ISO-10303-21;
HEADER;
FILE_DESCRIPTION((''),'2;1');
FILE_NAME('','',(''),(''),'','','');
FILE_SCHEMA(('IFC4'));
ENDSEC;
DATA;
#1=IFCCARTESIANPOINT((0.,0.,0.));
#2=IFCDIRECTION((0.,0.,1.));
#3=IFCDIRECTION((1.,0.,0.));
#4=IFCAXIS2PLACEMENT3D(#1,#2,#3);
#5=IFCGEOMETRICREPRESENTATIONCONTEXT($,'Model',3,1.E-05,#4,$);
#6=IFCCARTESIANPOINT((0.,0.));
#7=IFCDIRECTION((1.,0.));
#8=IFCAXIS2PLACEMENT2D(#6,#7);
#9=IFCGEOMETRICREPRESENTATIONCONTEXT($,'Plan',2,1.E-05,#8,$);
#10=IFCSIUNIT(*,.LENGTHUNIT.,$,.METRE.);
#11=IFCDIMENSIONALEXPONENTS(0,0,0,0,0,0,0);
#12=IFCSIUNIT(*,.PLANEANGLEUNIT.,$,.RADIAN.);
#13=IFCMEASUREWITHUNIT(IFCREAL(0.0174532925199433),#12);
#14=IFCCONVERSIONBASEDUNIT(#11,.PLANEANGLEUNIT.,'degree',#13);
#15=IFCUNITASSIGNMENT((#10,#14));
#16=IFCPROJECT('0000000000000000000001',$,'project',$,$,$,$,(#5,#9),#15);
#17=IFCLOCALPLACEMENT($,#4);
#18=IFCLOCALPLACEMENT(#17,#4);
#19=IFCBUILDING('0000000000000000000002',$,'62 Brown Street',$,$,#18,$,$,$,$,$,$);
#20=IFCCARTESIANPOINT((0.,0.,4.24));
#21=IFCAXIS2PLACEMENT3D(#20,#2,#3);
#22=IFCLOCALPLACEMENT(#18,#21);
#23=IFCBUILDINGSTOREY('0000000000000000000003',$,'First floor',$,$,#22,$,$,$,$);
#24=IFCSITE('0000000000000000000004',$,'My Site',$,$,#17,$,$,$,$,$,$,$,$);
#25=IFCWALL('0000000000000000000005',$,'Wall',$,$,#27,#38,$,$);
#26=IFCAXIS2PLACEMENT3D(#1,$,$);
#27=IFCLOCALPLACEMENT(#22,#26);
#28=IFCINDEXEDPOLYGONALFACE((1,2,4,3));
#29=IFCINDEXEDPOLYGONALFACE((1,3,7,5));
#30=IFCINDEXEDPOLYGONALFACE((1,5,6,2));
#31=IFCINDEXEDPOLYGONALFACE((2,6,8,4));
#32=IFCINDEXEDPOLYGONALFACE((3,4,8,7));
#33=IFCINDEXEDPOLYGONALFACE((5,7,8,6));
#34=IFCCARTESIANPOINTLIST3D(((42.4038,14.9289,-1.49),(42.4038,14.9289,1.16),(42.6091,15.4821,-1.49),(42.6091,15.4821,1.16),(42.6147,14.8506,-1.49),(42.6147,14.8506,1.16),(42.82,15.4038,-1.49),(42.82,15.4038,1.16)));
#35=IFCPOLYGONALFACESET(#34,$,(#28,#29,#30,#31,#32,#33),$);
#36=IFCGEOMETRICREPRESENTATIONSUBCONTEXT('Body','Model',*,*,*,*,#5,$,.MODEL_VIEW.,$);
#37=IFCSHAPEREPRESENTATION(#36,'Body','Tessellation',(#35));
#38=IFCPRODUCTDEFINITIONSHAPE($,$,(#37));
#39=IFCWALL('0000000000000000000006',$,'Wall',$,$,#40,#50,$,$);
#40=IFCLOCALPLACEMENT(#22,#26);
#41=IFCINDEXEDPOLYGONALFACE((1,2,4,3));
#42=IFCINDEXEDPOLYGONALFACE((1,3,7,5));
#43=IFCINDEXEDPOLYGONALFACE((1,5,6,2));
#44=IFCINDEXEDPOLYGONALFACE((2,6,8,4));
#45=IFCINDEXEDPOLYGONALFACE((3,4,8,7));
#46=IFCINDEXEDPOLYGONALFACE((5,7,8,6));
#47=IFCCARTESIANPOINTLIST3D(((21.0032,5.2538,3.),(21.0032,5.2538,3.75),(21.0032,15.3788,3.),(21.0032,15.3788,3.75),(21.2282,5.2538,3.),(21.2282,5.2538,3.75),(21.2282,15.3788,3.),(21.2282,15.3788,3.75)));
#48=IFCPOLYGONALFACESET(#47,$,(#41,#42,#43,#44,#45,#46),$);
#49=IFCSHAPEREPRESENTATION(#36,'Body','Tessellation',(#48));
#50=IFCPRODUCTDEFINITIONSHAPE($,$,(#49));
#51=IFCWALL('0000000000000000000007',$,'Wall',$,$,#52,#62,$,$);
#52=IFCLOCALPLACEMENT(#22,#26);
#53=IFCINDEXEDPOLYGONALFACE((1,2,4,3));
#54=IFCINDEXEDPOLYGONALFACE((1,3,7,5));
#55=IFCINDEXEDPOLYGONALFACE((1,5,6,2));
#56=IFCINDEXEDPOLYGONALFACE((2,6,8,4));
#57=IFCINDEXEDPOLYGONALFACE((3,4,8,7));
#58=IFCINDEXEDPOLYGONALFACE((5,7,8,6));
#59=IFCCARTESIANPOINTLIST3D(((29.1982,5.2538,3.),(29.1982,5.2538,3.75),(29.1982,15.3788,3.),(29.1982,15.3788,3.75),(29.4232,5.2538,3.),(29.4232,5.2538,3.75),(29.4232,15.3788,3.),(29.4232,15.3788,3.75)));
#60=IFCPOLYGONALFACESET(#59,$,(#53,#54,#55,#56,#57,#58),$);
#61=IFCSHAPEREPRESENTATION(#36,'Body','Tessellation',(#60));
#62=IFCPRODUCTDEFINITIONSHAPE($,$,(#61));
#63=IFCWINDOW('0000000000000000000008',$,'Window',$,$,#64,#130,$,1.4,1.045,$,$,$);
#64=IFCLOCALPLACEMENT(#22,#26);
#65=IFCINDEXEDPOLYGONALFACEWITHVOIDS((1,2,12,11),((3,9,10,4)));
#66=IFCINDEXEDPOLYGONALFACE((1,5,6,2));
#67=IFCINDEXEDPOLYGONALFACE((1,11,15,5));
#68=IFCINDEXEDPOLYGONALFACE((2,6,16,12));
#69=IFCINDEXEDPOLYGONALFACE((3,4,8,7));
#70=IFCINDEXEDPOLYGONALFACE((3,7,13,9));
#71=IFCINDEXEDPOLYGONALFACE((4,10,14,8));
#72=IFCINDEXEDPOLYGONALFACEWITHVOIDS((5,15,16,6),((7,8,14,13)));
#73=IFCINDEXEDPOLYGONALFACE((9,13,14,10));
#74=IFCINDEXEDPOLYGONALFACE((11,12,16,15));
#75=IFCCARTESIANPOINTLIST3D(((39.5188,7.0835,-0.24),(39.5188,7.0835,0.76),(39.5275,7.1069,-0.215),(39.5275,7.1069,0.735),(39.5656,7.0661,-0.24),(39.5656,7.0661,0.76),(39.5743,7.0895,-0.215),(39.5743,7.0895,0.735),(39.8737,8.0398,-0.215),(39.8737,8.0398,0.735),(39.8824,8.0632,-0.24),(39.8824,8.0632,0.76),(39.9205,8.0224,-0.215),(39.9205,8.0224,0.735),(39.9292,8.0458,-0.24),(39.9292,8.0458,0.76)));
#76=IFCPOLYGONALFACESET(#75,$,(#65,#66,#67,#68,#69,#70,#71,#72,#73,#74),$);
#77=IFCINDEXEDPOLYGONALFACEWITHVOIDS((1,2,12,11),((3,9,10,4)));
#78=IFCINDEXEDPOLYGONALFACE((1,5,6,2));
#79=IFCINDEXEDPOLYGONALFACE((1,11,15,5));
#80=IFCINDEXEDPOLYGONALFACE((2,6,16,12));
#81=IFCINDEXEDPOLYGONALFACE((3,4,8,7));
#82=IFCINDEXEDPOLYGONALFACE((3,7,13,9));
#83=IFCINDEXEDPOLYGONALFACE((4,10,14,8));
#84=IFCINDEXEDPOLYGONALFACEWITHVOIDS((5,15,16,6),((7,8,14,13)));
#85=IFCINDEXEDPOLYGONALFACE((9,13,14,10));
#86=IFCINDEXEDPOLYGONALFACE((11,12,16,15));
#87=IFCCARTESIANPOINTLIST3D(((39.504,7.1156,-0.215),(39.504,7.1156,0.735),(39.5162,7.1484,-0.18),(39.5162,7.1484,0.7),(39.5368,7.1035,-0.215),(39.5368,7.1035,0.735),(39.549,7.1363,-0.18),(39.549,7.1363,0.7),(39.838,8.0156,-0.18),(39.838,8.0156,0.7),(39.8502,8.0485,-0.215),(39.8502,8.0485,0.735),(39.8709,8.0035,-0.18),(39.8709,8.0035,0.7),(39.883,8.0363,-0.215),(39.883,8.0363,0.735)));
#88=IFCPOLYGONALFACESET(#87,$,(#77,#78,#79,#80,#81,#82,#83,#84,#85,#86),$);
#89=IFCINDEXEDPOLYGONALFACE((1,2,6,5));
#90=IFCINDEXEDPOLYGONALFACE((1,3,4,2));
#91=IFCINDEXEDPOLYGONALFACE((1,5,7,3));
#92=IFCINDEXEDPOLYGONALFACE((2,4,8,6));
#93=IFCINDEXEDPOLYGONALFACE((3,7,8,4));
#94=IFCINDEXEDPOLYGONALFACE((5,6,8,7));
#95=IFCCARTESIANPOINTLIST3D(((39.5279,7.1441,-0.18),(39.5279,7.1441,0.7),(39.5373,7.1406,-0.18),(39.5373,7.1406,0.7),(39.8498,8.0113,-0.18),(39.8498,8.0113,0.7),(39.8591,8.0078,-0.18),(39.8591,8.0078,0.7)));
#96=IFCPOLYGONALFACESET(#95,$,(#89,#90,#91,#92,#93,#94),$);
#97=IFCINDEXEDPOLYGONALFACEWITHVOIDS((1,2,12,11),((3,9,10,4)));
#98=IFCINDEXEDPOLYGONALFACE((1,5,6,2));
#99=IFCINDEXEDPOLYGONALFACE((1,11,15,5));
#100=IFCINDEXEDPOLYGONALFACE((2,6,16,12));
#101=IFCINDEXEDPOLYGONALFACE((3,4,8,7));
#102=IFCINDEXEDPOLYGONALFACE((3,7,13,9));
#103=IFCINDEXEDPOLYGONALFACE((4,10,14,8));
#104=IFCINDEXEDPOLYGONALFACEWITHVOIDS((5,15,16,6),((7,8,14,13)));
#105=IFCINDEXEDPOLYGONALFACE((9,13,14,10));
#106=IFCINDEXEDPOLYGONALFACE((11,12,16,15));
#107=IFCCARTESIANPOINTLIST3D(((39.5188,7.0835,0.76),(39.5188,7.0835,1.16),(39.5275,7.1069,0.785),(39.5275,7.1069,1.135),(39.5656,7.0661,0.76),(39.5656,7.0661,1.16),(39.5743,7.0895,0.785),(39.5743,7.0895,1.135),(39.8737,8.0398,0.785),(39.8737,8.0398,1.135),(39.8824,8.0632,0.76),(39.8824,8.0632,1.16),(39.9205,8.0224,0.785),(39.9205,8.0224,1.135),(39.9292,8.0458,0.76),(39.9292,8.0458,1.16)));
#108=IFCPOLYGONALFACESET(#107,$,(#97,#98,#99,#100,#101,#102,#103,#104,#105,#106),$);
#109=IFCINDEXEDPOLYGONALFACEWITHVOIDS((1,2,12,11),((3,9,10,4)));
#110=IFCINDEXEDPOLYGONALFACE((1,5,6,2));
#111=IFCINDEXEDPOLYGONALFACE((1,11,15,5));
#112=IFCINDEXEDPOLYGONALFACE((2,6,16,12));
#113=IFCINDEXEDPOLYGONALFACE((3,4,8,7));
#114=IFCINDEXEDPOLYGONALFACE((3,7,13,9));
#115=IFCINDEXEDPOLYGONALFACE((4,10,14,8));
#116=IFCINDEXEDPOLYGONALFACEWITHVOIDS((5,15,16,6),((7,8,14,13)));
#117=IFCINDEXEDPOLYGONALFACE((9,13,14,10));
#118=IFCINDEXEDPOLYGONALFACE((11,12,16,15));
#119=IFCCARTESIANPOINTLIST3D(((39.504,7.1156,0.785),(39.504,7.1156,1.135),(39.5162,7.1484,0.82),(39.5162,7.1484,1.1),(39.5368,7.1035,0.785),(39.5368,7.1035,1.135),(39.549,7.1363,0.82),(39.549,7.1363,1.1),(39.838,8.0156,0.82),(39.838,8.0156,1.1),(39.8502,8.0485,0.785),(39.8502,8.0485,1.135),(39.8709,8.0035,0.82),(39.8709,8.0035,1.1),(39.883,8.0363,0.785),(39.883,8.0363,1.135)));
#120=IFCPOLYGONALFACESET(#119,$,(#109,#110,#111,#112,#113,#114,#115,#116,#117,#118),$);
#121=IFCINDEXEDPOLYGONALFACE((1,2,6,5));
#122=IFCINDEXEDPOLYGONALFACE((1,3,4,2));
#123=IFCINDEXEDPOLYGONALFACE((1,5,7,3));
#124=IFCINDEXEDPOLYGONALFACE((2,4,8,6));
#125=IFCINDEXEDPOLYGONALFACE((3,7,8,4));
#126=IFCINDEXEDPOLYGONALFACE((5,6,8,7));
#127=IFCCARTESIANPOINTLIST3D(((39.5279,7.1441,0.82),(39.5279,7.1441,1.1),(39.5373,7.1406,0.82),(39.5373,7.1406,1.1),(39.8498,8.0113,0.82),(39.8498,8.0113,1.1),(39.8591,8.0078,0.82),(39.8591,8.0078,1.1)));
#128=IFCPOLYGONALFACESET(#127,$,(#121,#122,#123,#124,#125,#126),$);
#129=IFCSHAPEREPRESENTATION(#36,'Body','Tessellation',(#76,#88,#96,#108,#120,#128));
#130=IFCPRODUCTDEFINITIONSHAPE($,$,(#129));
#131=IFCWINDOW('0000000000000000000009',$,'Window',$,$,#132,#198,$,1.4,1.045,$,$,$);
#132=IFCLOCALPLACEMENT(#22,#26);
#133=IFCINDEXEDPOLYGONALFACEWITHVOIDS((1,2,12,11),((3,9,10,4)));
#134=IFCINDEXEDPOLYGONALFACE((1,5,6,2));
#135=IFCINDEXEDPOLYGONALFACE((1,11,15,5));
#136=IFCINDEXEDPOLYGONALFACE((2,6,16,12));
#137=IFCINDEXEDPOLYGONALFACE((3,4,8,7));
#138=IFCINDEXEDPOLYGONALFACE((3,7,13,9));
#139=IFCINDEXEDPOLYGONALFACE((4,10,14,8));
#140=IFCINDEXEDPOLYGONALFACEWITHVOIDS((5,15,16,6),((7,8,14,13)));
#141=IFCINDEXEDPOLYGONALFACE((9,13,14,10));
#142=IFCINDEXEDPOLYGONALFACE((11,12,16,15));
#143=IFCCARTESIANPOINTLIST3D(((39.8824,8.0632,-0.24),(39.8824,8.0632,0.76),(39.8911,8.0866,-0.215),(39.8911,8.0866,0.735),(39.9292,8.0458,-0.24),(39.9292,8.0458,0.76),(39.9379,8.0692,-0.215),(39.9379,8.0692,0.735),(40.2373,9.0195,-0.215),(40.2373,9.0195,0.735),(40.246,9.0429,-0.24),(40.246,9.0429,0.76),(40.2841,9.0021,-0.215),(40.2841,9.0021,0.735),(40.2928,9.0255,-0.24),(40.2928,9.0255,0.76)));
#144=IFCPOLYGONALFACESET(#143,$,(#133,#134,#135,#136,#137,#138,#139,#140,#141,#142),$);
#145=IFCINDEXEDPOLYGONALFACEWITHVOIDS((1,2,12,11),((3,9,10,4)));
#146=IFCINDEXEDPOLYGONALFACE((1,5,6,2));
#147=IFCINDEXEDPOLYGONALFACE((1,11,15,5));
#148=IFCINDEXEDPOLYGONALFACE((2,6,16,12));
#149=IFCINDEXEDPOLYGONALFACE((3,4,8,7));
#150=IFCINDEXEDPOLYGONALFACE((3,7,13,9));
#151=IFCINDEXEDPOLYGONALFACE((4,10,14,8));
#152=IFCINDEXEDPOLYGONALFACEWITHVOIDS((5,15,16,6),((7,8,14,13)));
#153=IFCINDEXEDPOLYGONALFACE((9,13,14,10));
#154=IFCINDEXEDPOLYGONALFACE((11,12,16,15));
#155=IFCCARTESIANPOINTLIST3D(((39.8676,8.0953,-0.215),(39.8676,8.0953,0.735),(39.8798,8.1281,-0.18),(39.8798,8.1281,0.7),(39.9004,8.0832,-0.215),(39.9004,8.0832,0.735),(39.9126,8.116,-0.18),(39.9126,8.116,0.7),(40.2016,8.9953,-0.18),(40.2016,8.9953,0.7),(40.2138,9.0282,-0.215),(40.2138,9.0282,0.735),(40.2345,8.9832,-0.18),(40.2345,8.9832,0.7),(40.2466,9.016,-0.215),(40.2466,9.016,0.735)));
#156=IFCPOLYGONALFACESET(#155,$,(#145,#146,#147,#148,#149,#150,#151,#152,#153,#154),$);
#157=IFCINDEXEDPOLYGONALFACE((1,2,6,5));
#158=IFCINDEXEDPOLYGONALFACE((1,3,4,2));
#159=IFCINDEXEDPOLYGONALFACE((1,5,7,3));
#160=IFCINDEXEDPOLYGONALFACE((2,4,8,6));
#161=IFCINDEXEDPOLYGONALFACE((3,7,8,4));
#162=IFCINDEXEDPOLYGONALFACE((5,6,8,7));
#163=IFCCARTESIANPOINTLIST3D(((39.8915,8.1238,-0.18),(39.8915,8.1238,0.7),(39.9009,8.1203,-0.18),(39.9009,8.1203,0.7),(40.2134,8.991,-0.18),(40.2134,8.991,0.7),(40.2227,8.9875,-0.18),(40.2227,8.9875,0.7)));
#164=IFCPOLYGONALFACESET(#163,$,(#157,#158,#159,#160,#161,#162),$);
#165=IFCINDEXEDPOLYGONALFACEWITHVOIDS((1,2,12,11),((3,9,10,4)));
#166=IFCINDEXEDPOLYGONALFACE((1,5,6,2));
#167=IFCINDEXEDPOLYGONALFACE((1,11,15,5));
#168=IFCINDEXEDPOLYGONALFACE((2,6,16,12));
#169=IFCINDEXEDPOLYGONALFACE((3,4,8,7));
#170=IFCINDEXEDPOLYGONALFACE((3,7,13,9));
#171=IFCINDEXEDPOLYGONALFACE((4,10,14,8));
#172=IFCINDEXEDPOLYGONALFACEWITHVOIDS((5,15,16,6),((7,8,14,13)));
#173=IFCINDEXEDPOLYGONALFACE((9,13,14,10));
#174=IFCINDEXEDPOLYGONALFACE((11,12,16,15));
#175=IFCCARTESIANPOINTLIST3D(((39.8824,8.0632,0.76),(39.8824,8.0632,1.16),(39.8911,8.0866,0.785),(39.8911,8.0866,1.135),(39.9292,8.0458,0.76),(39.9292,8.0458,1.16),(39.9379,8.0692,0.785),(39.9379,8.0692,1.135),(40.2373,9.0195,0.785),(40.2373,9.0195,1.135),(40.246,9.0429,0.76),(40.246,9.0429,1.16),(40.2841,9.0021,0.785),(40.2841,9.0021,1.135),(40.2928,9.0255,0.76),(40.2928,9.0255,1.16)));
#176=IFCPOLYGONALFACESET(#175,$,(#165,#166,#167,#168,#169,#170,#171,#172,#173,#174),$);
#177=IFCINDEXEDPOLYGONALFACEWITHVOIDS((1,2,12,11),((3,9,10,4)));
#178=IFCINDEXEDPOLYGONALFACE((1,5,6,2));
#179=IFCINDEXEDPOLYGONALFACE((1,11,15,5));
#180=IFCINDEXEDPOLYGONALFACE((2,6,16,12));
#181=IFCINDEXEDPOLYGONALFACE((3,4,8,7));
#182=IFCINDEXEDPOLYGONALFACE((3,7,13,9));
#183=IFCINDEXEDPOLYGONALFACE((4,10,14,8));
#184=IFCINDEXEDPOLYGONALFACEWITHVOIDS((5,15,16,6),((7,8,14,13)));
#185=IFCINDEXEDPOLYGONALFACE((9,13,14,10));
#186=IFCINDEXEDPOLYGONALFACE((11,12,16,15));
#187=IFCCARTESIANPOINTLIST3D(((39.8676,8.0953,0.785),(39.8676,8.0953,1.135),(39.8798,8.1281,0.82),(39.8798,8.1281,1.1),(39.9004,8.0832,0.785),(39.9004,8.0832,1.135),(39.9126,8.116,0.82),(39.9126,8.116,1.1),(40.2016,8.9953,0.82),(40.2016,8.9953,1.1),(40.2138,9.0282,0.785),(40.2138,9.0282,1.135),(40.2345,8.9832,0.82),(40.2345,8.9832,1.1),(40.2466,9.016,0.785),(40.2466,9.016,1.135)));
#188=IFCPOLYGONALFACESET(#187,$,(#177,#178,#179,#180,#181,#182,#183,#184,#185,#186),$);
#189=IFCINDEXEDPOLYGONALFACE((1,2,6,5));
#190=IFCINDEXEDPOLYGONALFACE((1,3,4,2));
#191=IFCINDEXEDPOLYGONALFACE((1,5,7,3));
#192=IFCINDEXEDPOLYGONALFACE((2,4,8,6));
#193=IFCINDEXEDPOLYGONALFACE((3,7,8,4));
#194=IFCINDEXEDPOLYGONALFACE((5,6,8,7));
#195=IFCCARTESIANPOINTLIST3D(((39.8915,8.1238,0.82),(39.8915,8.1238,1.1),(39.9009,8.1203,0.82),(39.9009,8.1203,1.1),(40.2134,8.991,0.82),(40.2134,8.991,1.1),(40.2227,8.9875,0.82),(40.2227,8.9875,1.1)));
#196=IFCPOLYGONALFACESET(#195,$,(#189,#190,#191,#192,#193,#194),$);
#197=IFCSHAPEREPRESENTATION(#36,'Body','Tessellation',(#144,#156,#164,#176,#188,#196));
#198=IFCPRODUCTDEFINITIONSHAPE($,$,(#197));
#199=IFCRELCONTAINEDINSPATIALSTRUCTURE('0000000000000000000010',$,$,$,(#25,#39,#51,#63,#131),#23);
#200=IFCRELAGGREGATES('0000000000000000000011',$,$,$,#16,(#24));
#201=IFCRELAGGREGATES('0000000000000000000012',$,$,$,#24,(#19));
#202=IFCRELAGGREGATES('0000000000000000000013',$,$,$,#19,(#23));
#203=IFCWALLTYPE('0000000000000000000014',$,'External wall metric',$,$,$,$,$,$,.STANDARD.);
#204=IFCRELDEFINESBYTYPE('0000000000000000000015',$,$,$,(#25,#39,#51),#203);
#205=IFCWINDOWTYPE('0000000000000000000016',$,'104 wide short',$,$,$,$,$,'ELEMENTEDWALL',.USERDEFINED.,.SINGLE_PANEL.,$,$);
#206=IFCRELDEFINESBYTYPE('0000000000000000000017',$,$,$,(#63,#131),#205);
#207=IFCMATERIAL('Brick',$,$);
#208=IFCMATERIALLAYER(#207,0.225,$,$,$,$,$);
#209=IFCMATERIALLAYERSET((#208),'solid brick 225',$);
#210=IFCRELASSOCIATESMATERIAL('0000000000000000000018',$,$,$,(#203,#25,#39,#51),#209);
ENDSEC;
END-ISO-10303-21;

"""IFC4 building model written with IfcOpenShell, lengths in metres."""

from ifc_helpers import new_model, entity, si_unit, converted_unit, frame, origin_with_axes, origin_2d_with_axis, place, context, subcontext, project, spatial, line, indexed_curve, outline, extrude, shape, source, transform, mapped, material, layer, layer_set, layer_usage, type_object, type_shapes, element, save


model = new_model("IFC4")

# Units and contexts
model_context = context("Model", 3, precision=1e-05, world=origin_with_axes())
plan_context = context("Plan", 2, precision=1e-05, world=origin_2d_with_axis())
body_context_1 = subcontext(model_context, "Body", "Model", "MODEL_VIEW")
body_context_2 = subcontext(plan_context, "Body", "Plan", "PLAN_VIEW")
ifc_project = project(units=[si_unit("LENGTHUNIT", "METRE"), converted_unit("PLANEANGLEUNIT", "degree", entity("IfcReal", 0.0174532925199433), si_unit("PLANEANGLEUNIT", "RADIAN"), dimensions=[0, 0, 0, 0, 0, 0, 0])], contexts=[model_context, plan_context])

# Site, building, storey
site_placement = place(None, origin_with_axes())
site = spatial("IfcSite", under=ifc_project, at=site_placement, Name="My Site")
building_placement = place(site_placement, origin_with_axes())
building = spatial("IfcBuilding", under=site, at=building_placement, Name="62 Brown Street")
storey_placement = place(building_placement, frame((0.0, 0.0, 4.24), z_axis=(0.0, 0.0, 1.0), x_axis=(1.0, 0.0, 0.0)))
storey = spatial("IfcBuildingStorey", under=building, at=storey_placement, Name="First floor")

# Shared definitions
ifc_material_1 = material(Name="Brick")
ifc_layer_1 = layer(ifc_material_1, 0.225)
ifc_layer_set_1 = layer_set([ifc_layer_1], Name="solid brick 225")
wall_type_1 = type_object("IfcWallType", Name="External wall metric", PredefinedType="STANDARD", material=ifc_layer_set_1)

# Shared definitions
window_type = type_object("IfcWindowType", Name="104 wide short", ElementType="ELEMENTEDWALL", PartitioningType="SINGLE_PANEL", PredefinedType="USERDEFINED")
shared_shape_1 = source(origin_with_axes(), body_context_1, "Body", "SweptSolid", [
    extrude(outline(indexed_curve([(0.0, 0.0), (1.045, 0.0), (1.045, 1.0), (0.0, 1.0)], segments=[line(1, 2, 3, 4, 1)]), holes=[indexed_curve([(0.025, 0.025), (1.02, 0.025), (1.02, 0.975), (0.025, 0.975)], segments=[line(1, 2, 3, 4, 1)])]), frame((0.0, 0.15, 0.0), z_axis=(0.0, -1.0, 0.0), x_axis=(1.0, 0.0, 0.0)), (0.0, 0.0, -1.0), 0.05),
    extrude(outline(indexed_curve([(0.0, 0.0), (0.995, 0.0), (0.995, 0.95), (0.0, 0.95)], segments=[line(1, 2, 3, 4, 1)]), holes=[indexed_curve([(0.035, 0.035), (0.96, 0.035), (0.96, 0.915), (0.035, 0.915)], segments=[line(1, 2, 3, 4, 1)])]), frame((0.025, 0.19, 0.025), z_axis=(0.0, -1.0, 0.0), x_axis=(1.0, 0.0, 0.0)), (0.0, 0.0, -1.0), 0.035),
    extrude(outline(indexed_curve([(0.035, 0.035), (0.96, 0.035), (0.96, 0.915), (0.035, 0.915)], segments=[line(1, 2, 3, 4, 1)])), frame((0.025, 0.2025, 0.025), z_axis=(0.0, -1.0, 0.0), x_axis=(1.0, 0.0, 0.0)), (0.0, 0.0, -1.0), 0.01),
    extrude(outline(indexed_curve([(0.0, 0.0), (1.045, 0.0), (1.045, 0.4), (0.0, 0.4)], segments=[line(1, 2, 3, 4, 1)]), holes=[indexed_curve([(0.025, 0.025), (1.02, 0.025), (1.02, 0.375), (0.025, 0.375)], segments=[line(1, 2, 3, 4, 1)])]), frame((0.0, 0.15, 1.0), z_axis=(0.0, -1.0, 0.0), x_axis=(1.0, 0.0, 0.0)), (0.0, 0.0, -1.0), 0.05),
    extrude(outline(indexed_curve([(0.0, 0.0), (0.995, 0.0), (0.995, 0.35), (0.0, 0.35)], segments=[line(1, 2, 3, 4, 1)]), holes=[indexed_curve([(0.035, 0.035), (0.96, 0.035), (0.96, 0.315), (0.035, 0.315)], segments=[line(1, 2, 3, 4, 1)])]), frame((0.025, 0.19, 1.025), z_axis=(0.0, -1.0, 0.0), x_axis=(1.0, 0.0, 0.0)), (0.0, 0.0, -1.0), 0.035),
    extrude(outline(indexed_curve([(0.035, 0.035), (0.96, 0.035), (0.96, 0.315), (0.035, 0.315)], segments=[line(1, 2, 3, 4, 1)])), frame((0.025, 0.2025, 1.025), z_axis=(0.0, -1.0, 0.0), x_axis=(1.0, 0.0, 0.0)), (0.0, 0.0, -1.0), 0.01),
])
shared_shape_2 = source(origin_with_axes(), body_context_2, "Body", "Curve2D", [
    entity("IfcIndexedPolyCurve", entity("IfcCartesianPointList2D", [[0.025, 0.15], [1.02, 0.15]])),
    entity("IfcIndexedPolyCurve", entity("IfcCartesianPointList2D", [[0.0, 0.2], [0.025, 0.2], [0.025, 0.15], [0.0, 0.15]]), [entity("IfcLineIndex", [1, 2, 3, 4, 1])]),
    entity("IfcIndexedPolyCurve", entity("IfcCartesianPointList2D", [[1.045, 0.2], [1.02, 0.2], [1.02, 0.15], [1.045, 0.15]]), [entity("IfcLineIndex", [1, 2, 3, 4, 1])]),
    entity("IfcIndexedPolyCurve", entity("IfcCartesianPointList2D", [[0.025, 0.19], [0.06, 0.19], [0.06, 0.225], [0.025, 0.225]]), [entity("IfcLineIndex", [1, 2, 3, 4, 1])]),
    entity("IfcIndexedPolyCurve", entity("IfcCartesianPointList2D", [[1.02, 0.19], [0.985, 0.19], [0.985, 0.225], [1.02, 0.225]]), [entity("IfcLineIndex", [1, 2, 3, 4, 1])]),
    entity("IfcIndexedPolyCurve", entity("IfcCartesianPointList2D", [[0.06, 0.19], [0.985, 0.19]])),
    entity("IfcIndexedPolyCurve", entity("IfcCartesianPointList2D", [[0.06, 0.225], [0.985, 0.225]])),
    entity("IfcIndexedPolyCurve", entity("IfcCartesianPointList2D", [[0.06, 0.2075], [0.985, 0.2075]])),
])
type_shapes(window_type, [shared_shape_1, shared_shape_2])

# Walls
ifc_layer_usage_1 = layer_usage(ifc_layer_set_1, "AXIS2", "POSITIVE", 0.0)
wall_1_placement = place(storey_placement, frame((42.6147, 14.8506, -1.49), z_axis=(0.0, 0.0, 1.0), x_axis=(0.347944, 0.937515, 0.0)))
element("IfcWall", 1, at=wall_1_placement, inside=storey, type_object=wall_type_1, material=ifc_layer_usage_1, Name="Wall", context=body_context_1, shape_type="SweptSolid", body=[
    extrude(outline(indexed_curve([(0.0, 0.0), (0.0, 0.225), (0.5901, 0.225), (0.5901, 0.0), (0.0, 0.0)], self_intersect=False)), origin_with_axes(), (0.0, 0.0, 1.0), 2.65),
])
ifc_layer_usage_2 = layer_usage(ifc_layer_set_1, "AXIS2", "POSITIVE", 0.0)
wall_2_placement = place(storey_placement, frame((21.0032, 15.3788, 3.0), z_axis=(0.0, 0.0, 1.0), x_axis=(0.0, -1.0, 0.0)))
element("IfcWall", 2, at=wall_2_placement, inside=storey, type_object=wall_type_1, material=ifc_layer_usage_2, Name="Wall", context=body_context_1, shape_type="SweptSolid", body=[
    extrude(outline(indexed_curve([(0.0, 0.0), (0.0, 0.225), (10.125, 0.225), (10.125, 0.0), (0.0, 0.0)], self_intersect=False)), origin_with_axes(), (0.0, 0.0, 1.0), 0.75),
])
ifc_layer_usage_3 = layer_usage(ifc_layer_set_1, "AXIS2", "POSITIVE", 0.0)
wall_3_placement = place(storey_placement, frame((29.4232, 5.2538, 3.0), z_axis=(0.0, 0.0, 1.0), x_axis=(0.0, 1.0, 0.0)))
element("IfcWall", 3, at=wall_3_placement, inside=storey, type_object=wall_type_1, material=ifc_layer_usage_3, Name="Wall", context=body_context_1, shape_type="SweptSolid", body=[
    extrude(outline(indexed_curve([(0.0, 0.0), (0.0, 0.225), (10.125, 0.225), (10.125, 0.0), (0.0, 0.0)], self_intersect=False)), origin_with_axes(), (0.0, 0.0, 1.0), 0.75),
])

# Windows
for number, where, z_axis, x_axis, name in (
    (4, (39.7063, 7.0139, -0.24), (0.0, 0.0, 1.0), (0.347944, 0.937515, 0.0), "Window"),
    (5, (40.0699, 7.9936, -0.24), (0.0, 0.0, 1.0), (0.347944, 0.937515, 0.0), "Window"),
):
    element("IfcWindow", number, at=place(storey_placement, frame(where, z_axis=z_axis, x_axis=x_axis)), inside=storey, type_object=window_type, Name=name, OverallHeight=1.4, OverallWidth=1.045, shapes=[
        shape(body_context_1, "Body", "MappedRepresentation", [mapped(shared_shape_1, transform((0.0, 0.0, 0.0), x_axis=(1.0, 0.0, 0.0), y_axis=(0.0, 1.0, 0.0), z_axis=(0.0, 0.0, 1.0), scale=1.0))]),
        shape(body_context_2, "Body", "MappedRepresentation", [mapped(shared_shape_2, transform((0.0, 0.0, 0.0), x_axis=(1.0, 0.0, 0.0), y_axis=(0.0, 1.0, 0.0), z_axis=(0.0, 0.0, 1.0), scale=1.0))]),
    ])

save(model, "model.ifc")
